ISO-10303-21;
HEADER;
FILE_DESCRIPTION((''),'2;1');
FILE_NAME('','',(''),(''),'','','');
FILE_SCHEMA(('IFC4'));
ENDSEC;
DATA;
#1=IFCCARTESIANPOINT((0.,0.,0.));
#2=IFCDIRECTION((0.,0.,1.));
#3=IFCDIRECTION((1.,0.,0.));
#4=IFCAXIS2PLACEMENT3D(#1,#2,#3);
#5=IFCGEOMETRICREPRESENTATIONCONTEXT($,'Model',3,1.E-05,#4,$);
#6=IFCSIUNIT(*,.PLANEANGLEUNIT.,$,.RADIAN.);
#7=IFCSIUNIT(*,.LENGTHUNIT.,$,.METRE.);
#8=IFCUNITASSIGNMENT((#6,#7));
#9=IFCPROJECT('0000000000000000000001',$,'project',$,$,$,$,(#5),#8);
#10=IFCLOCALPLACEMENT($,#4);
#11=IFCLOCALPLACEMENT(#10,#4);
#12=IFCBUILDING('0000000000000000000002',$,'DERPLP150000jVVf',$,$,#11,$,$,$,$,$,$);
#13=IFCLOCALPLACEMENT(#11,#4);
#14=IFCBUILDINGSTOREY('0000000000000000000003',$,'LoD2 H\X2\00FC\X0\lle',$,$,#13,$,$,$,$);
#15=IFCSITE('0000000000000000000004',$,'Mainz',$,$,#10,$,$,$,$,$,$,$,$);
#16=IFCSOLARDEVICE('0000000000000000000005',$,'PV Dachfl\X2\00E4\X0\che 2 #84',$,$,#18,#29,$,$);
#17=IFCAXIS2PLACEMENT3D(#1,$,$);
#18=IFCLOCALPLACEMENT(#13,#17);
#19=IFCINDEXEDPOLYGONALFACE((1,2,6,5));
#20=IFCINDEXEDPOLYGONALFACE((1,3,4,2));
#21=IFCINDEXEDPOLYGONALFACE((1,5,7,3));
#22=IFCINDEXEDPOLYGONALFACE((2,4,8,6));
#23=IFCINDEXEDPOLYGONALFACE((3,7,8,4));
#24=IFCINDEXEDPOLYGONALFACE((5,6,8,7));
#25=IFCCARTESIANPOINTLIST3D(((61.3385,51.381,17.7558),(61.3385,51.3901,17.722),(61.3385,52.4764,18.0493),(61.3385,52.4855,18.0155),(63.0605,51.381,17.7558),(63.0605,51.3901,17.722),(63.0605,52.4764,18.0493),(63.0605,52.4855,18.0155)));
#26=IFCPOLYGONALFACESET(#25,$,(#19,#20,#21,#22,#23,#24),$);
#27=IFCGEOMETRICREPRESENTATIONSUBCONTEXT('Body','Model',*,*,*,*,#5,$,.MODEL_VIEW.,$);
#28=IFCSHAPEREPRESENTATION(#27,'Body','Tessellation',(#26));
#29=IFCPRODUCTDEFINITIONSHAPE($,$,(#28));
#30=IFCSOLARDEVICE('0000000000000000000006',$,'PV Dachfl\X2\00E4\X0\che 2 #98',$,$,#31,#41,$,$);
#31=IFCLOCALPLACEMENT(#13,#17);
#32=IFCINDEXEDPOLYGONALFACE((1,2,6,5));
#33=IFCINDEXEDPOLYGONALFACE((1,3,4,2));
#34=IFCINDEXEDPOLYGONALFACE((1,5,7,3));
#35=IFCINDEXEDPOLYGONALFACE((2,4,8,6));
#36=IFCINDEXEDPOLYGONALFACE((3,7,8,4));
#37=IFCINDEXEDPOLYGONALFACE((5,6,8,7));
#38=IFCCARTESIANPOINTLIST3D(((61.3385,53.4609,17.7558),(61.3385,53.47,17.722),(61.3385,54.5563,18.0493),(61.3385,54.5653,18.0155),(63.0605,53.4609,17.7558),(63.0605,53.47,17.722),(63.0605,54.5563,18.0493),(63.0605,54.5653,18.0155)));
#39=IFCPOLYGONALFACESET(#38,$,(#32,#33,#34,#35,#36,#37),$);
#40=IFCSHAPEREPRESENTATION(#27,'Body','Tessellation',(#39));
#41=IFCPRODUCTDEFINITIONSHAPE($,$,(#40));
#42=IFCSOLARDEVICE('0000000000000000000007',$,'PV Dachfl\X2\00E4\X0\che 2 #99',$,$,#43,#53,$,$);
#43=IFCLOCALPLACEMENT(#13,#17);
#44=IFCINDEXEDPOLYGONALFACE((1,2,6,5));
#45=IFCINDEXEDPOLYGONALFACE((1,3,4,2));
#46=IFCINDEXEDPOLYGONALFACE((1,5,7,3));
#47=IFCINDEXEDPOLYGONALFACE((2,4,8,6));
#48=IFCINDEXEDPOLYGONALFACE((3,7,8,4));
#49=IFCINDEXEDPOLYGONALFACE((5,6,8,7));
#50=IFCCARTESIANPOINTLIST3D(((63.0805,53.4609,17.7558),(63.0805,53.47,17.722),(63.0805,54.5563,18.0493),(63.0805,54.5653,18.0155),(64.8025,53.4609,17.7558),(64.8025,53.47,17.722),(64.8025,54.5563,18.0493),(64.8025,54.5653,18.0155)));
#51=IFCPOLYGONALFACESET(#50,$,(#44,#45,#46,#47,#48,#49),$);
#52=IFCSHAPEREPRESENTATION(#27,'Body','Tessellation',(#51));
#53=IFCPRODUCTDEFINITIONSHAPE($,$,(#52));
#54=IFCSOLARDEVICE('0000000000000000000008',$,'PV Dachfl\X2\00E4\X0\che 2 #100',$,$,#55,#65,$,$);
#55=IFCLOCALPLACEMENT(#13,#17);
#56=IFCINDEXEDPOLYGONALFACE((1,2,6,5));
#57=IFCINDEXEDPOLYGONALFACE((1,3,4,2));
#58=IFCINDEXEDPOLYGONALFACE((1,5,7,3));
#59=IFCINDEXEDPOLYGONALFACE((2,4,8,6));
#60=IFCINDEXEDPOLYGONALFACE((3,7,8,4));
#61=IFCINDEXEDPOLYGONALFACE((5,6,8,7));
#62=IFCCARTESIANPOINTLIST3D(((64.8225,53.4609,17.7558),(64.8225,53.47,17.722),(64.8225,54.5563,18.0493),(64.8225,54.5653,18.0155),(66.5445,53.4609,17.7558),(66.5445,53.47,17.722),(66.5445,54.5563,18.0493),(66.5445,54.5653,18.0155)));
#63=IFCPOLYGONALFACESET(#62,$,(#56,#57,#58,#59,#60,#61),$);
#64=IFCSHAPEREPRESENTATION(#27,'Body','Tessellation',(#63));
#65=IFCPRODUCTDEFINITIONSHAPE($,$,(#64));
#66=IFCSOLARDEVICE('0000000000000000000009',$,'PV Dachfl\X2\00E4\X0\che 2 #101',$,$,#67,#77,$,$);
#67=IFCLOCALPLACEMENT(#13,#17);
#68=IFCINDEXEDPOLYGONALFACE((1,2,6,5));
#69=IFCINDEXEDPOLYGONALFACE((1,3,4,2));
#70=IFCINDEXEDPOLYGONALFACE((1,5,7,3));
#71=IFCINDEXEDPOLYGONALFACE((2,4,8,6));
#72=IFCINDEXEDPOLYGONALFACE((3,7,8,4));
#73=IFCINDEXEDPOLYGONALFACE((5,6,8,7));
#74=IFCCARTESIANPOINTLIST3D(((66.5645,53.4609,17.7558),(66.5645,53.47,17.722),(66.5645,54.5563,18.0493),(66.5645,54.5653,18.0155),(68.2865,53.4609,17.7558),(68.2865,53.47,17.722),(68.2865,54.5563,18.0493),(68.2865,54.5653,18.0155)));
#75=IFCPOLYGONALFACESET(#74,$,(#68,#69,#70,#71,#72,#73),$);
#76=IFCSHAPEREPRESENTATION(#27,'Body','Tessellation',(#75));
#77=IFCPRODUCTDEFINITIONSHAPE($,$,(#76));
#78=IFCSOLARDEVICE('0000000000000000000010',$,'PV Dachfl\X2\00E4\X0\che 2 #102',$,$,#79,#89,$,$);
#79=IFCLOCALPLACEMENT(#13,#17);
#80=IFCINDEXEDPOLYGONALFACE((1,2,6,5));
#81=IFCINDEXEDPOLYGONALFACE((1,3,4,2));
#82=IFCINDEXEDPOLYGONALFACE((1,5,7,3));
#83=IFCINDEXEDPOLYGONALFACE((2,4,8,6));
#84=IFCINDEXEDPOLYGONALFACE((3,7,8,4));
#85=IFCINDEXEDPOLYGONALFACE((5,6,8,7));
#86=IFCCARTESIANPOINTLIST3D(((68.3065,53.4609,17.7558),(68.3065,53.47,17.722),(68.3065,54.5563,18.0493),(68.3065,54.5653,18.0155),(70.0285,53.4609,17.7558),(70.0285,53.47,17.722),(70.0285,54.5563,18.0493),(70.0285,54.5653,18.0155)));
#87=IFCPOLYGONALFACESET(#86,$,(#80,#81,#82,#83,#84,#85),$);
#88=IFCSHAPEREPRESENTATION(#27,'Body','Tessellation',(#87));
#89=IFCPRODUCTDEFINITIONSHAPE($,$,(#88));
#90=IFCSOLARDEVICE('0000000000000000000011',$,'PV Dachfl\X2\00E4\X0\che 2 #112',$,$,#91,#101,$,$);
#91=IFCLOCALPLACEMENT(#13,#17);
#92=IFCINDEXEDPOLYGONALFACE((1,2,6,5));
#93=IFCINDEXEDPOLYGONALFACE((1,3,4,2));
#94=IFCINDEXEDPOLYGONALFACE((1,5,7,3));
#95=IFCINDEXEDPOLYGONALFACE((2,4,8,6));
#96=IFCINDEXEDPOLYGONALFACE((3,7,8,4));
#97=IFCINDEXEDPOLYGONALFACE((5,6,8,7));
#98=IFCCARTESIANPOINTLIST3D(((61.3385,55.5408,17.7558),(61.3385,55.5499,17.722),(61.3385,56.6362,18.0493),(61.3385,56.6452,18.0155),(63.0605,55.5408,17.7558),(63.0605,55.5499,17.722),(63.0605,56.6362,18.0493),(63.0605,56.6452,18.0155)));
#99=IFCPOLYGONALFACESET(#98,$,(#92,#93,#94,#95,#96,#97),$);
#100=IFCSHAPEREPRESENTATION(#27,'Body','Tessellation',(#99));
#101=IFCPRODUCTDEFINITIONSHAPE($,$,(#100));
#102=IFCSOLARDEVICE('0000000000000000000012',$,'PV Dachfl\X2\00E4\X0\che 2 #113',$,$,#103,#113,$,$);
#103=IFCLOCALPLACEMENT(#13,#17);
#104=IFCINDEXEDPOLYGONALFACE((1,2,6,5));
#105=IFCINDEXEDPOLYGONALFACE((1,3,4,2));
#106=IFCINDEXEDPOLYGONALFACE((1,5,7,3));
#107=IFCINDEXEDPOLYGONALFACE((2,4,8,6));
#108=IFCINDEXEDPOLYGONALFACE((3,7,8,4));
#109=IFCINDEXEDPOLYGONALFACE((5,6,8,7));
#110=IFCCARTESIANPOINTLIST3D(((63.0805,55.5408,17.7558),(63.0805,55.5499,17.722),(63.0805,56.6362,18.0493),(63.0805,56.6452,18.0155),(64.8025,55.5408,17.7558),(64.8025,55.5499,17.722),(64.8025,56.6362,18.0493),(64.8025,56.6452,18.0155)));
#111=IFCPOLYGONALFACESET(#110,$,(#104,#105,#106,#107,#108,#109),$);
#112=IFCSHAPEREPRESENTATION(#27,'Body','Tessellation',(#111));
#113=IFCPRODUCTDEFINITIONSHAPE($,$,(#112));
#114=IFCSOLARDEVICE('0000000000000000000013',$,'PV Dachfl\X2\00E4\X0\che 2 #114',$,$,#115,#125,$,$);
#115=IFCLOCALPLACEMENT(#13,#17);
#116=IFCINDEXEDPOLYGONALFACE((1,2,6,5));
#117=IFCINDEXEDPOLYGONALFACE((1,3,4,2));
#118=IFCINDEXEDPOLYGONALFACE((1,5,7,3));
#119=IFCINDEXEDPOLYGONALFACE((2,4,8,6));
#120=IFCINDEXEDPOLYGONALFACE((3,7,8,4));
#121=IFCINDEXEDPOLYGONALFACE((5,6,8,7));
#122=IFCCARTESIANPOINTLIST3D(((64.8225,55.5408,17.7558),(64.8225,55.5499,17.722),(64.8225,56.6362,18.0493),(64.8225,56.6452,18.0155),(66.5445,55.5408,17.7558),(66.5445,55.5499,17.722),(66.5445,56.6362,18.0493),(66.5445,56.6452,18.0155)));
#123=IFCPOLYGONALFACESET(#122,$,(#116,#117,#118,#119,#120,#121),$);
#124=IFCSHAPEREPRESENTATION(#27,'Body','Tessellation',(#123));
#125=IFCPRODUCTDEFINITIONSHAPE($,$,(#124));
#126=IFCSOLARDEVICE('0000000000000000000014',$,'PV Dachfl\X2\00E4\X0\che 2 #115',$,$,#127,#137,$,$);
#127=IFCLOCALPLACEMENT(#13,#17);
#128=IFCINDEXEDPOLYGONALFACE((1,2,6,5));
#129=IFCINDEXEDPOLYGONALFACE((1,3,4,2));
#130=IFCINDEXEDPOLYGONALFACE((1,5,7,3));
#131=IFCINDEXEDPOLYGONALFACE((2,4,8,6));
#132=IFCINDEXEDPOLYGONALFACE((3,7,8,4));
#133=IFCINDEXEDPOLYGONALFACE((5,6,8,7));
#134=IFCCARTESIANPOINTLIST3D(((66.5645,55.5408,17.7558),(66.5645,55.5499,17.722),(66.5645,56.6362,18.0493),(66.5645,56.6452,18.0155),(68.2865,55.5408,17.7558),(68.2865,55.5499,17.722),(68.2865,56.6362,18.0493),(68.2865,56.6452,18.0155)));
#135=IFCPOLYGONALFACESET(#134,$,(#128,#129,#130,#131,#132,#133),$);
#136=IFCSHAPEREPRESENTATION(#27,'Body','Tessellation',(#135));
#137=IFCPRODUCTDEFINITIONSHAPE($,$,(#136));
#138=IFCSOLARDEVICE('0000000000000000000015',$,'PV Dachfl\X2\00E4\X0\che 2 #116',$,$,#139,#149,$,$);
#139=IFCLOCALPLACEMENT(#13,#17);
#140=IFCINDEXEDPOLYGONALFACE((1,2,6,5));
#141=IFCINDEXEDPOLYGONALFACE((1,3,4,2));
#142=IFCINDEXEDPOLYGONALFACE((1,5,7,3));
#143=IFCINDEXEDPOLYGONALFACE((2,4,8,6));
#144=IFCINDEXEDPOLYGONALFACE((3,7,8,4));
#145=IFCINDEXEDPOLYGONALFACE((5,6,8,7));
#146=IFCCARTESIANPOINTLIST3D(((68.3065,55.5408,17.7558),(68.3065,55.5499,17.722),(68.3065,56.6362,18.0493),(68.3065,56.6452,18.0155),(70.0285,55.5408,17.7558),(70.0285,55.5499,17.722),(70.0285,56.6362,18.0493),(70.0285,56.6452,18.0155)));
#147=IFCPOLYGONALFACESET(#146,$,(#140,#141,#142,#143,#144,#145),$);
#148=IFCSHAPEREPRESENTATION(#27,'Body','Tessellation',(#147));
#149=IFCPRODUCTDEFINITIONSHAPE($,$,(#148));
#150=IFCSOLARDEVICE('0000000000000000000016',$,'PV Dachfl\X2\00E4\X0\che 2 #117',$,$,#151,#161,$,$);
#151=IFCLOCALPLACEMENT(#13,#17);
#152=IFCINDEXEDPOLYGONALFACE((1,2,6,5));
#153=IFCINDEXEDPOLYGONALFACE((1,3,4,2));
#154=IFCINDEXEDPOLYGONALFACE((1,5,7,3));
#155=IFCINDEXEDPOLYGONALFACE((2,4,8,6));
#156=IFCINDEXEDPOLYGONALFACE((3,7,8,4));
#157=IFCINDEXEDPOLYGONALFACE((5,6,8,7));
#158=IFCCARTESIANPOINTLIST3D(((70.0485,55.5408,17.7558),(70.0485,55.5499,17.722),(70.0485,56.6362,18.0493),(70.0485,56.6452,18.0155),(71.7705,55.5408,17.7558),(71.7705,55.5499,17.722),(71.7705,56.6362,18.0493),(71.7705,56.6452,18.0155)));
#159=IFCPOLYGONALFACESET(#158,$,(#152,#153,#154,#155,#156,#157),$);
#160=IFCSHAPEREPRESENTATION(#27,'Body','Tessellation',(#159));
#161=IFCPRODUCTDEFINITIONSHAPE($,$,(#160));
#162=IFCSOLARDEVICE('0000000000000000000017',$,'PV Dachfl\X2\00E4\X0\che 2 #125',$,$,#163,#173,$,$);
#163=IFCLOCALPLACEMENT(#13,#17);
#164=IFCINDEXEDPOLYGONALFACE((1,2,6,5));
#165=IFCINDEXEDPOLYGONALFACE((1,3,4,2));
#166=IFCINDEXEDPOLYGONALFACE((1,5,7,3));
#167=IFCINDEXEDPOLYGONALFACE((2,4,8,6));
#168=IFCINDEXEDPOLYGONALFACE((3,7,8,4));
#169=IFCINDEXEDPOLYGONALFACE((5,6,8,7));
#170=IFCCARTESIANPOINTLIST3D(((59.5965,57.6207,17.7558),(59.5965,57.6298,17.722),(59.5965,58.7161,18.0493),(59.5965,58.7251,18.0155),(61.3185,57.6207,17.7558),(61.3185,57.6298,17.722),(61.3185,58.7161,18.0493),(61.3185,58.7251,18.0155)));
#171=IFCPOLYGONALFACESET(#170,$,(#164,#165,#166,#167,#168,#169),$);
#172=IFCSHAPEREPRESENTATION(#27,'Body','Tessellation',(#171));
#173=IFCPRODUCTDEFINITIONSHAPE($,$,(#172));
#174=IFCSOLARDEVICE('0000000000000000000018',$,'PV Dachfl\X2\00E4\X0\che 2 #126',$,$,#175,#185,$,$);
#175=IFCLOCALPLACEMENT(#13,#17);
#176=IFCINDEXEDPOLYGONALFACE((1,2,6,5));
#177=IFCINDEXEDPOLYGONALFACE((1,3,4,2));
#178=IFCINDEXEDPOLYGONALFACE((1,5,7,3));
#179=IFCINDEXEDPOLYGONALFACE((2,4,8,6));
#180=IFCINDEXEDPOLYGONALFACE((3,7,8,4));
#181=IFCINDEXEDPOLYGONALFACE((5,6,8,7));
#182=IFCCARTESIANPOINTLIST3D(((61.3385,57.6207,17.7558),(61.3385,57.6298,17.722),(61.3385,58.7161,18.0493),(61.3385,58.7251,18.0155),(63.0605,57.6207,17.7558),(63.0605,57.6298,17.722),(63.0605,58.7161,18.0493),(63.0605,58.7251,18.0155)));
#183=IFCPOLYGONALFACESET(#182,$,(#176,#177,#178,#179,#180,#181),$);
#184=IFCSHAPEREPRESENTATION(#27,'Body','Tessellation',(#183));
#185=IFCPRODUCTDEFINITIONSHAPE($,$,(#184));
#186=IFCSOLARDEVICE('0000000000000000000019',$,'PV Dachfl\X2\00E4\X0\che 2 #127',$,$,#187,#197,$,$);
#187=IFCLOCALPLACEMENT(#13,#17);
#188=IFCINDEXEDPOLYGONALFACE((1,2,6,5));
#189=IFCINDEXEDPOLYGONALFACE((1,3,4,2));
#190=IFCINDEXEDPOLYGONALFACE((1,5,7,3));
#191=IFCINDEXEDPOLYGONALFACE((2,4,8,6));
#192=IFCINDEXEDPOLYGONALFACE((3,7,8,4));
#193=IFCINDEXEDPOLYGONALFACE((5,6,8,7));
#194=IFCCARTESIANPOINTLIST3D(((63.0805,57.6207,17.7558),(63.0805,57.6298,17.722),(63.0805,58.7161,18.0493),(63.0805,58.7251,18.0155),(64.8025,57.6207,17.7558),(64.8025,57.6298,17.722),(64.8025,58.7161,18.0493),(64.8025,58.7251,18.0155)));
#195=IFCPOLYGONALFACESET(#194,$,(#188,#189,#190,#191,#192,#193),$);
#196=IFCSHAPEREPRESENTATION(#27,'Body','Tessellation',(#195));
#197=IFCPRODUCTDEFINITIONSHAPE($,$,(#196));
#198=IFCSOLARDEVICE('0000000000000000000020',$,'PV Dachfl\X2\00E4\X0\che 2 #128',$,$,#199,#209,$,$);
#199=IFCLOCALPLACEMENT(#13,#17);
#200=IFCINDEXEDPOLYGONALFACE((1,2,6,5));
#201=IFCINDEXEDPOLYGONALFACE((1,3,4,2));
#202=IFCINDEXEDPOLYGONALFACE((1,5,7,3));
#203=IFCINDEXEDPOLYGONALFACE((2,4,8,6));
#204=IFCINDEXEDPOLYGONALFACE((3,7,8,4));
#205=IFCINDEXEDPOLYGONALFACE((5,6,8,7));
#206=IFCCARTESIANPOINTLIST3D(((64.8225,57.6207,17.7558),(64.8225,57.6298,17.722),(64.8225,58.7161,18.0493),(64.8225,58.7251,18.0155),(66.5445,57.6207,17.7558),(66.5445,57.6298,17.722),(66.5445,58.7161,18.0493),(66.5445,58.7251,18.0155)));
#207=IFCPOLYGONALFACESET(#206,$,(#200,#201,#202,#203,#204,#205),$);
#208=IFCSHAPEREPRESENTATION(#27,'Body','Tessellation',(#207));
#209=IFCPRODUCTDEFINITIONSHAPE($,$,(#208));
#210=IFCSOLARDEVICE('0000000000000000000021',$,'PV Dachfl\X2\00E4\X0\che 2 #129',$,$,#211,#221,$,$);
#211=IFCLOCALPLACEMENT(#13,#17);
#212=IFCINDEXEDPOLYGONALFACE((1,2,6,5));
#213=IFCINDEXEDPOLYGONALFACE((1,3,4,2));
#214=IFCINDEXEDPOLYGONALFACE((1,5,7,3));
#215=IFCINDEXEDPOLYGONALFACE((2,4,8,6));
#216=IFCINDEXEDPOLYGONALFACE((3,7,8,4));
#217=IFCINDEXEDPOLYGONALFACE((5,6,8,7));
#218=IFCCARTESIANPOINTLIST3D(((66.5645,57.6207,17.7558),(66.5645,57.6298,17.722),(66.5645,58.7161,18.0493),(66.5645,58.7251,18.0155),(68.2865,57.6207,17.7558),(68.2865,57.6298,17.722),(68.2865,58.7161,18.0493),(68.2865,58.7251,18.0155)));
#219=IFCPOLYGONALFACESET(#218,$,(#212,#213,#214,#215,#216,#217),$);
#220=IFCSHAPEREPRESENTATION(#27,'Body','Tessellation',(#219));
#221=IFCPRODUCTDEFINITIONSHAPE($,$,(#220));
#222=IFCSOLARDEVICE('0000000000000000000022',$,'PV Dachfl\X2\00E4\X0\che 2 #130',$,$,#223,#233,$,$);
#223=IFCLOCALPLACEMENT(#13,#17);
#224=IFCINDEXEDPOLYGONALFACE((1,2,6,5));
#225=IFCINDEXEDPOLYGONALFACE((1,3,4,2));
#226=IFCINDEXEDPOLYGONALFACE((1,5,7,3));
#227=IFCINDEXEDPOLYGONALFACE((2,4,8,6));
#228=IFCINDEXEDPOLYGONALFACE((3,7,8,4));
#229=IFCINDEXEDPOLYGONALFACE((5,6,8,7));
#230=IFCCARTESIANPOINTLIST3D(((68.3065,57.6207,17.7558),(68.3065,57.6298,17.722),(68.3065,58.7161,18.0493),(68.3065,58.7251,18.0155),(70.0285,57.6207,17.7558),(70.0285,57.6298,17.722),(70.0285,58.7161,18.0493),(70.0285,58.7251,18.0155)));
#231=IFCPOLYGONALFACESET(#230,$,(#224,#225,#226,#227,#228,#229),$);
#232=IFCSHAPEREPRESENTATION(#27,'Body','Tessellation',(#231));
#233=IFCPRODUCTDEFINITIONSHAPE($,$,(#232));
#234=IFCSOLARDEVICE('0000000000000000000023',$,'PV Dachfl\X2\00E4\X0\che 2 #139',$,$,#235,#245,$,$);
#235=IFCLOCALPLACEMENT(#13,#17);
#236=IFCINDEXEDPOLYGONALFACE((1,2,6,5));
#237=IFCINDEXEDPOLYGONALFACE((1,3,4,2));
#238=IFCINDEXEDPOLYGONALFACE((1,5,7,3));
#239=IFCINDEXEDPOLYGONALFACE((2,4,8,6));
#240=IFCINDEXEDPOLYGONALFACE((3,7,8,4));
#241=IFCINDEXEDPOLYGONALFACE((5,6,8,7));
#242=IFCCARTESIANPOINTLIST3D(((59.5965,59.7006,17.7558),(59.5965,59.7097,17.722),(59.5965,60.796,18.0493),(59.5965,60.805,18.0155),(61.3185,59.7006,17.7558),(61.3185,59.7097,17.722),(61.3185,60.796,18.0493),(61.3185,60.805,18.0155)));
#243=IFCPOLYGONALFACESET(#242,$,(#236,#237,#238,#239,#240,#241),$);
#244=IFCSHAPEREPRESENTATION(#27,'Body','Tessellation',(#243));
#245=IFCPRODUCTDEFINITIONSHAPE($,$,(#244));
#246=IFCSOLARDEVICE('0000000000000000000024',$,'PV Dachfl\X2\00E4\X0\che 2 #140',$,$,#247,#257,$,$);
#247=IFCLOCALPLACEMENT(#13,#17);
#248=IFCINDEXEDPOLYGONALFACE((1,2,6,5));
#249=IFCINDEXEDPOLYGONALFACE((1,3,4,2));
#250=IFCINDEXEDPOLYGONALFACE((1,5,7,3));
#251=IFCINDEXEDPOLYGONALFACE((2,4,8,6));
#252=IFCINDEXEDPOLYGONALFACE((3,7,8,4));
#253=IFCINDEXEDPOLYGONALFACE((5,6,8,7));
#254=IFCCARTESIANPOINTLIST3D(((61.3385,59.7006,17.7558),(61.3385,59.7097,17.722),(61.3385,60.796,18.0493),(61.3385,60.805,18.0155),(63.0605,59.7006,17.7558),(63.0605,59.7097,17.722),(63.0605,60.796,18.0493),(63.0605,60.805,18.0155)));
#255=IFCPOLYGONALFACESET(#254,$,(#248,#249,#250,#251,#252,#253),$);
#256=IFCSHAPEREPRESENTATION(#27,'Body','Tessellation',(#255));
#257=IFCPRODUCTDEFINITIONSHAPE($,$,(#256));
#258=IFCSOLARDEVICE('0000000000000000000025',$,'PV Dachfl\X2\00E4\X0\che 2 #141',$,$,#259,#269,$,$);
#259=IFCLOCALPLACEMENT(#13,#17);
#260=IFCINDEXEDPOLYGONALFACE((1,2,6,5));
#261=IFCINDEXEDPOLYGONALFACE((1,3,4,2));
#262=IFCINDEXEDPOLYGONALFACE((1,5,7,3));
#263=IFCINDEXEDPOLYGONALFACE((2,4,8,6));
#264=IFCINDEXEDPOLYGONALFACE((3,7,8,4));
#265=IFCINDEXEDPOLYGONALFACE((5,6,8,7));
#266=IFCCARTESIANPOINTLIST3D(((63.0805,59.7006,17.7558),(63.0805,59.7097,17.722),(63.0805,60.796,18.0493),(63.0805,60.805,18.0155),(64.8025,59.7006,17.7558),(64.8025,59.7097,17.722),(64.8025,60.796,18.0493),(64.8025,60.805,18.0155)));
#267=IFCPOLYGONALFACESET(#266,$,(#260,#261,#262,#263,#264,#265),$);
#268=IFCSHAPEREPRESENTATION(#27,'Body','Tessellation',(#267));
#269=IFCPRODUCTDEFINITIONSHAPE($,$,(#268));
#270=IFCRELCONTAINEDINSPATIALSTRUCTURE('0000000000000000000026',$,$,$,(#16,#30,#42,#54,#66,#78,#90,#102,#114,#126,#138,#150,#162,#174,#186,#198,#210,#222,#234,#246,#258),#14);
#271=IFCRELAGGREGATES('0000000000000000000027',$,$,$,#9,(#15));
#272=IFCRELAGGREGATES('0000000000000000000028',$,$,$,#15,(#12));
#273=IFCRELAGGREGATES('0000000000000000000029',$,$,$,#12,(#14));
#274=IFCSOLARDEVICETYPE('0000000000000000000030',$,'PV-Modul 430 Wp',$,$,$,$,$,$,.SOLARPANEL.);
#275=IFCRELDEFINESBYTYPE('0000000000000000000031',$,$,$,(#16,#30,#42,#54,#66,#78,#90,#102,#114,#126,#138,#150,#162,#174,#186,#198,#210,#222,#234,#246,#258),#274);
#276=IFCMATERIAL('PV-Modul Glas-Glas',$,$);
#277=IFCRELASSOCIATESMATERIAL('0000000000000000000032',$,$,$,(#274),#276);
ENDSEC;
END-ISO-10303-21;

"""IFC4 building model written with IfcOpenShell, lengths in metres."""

from ifc_helpers import new_model, si_unit, frame, frame_2d, origin, origin_with_axes, place, context, subcontext, project, spatial, rectangle, extrude, source, transform, mapped, material, type_object, type_shapes, element, save


model = new_model("IFC4")

# Units and contexts
model_context = context("Model", 3, precision=1e-05, world=origin_with_axes())
body_context = subcontext(model_context, "Body", "Model", "MODEL_VIEW")
ifc_project = project(units=[si_unit("PLANEANGLEUNIT", "RADIAN"), si_unit("LENGTHUNIT", "METRE")], contexts=[model_context])

# Site, building, storey
site_placement = place(None, origin_with_axes())
site = spatial("IfcSite", under=ifc_project, at=site_placement, Name="Mainz")
building_placement = place(site_placement, origin_with_axes())
building = spatial("IfcBuilding", under=site, at=building_placement, Name="DERPLP150000jVVf")
storey_placement = place(building_placement, origin_with_axes())
storey = spatial("IfcBuildingStorey", under=building, at=storey_placement, Name="LoD2 Hülle")

# Solar devices
ifc_material = material(Name="PV-Modul Glas-Glas")
solar_device_type = type_object("IfcSolarDeviceType", Name="PV-Modul 430 Wp", PredefinedType="SOLARPANEL", material=ifc_material)
shared_shape = source(origin_with_axes(), body_context, "Body", "SweptSolid", [
    extrude(rectangle(XDim=1.722, YDim=1.134, at=frame_2d((0.861, 0.567))), origin(), (0.0, 0.0, 1.0), 0.035),
])
type_shapes(solar_device_type, [shared_shape])
for number, where, z_axis, x_axis, name in (
    (1, (61.3385, 51.3901, 17.722), (0.0, -0.258819, 0.965926), (1.0, 0.0, 0.0), "PV Dachfläche 2 #84"),
    (2, (61.3385, 53.47, 17.722), (0.0, -0.258819, 0.965926), (1.0, 0.0, 0.0), "PV Dachfläche 2 #98"),
    (3, (63.0805, 53.47, 17.722), (0.0, -0.258819, 0.965926), (1.0, 0.0, 0.0), "PV Dachfläche 2 #99"),
    (4, (64.8225, 53.47, 17.722), (0.0, -0.258819, 0.965926), (1.0, 0.0, 0.0), "PV Dachfläche 2 #100"),
    (5, (66.5645, 53.47, 17.722), (0.0, -0.258819, 0.965926), (1.0, 0.0, 0.0), "PV Dachfläche 2 #101"),
    (6, (68.3065, 53.47, 17.722), (0.0, -0.258819, 0.965926), (1.0, 0.0, 0.0), "PV Dachfläche 2 #102"),
    (7, (61.3385, 55.5499, 17.722), (0.0, -0.258819, 0.965926), (1.0, 0.0, 0.0), "PV Dachfläche 2 #112"),
    (8, (63.0805, 55.5499, 17.722), (0.0, -0.258819, 0.965926), (1.0, 0.0, 0.0), "PV Dachfläche 2 #113"),
    (9, (64.8225, 55.5499, 17.722), (0.0, -0.258819, 0.965926), (1.0, 0.0, 0.0), "PV Dachfläche 2 #114"),
    (10, (66.5645, 55.5499, 17.722), (0.0, -0.258819, 0.965926), (1.0, 0.0, 0.0), "PV Dachfläche 2 #115"),
    (11, (68.3065, 55.5499, 17.722), (0.0, -0.258819, 0.965926), (1.0, 0.0, 0.0), "PV Dachfläche 2 #116"),
    (12, (70.0485, 55.5499, 17.722), (0.0, -0.258819, 0.965926), (1.0, 0.0, 0.0), "PV Dachfläche 2 #117"),
    (13, (59.5965, 57.6298, 17.722), (0.0, -0.258819, 0.965926), (1.0, 0.0, 0.0), "PV Dachfläche 2 #125"),
    (14, (61.3385, 57.6298, 17.722), (0.0, -0.258819, 0.965926), (1.0, 0.0, 0.0), "PV Dachfläche 2 #126"),
    (15, (63.0805, 57.6298, 17.722), (0.0, -0.258819, 0.965926), (1.0, 0.0, 0.0), "PV Dachfläche 2 #127"),
    (16, (64.8225, 57.6298, 17.722), (0.0, -0.258819, 0.965926), (1.0, 0.0, 0.0), "PV Dachfläche 2 #128"),
    (17, (66.5645, 57.6298, 17.722), (0.0, -0.258819, 0.965926), (1.0, 0.0, 0.0), "PV Dachfläche 2 #129"),
    (18, (68.3065, 57.6298, 17.722), (0.0, -0.258819, 0.965926), (1.0, 0.0, 0.0), "PV Dachfläche 2 #130"),
    (19, (59.5965, 59.7097, 17.722), (0.0, -0.258819, 0.965926), (1.0, 0.0, 0.0), "PV Dachfläche 2 #139"),
    (20, (61.3385, 59.7097, 17.722), (0.0, -0.258819, 0.965926), (1.0, 0.0, 0.0), "PV Dachfläche 2 #140"),
    (21, (63.0805, 59.7097, 17.722), (0.0, -0.258819, 0.965926), (1.0, 0.0, 0.0), "PV Dachfläche 2 #141"),
):
    element("IfcSolarDevice", number, at=place(storey_placement, frame(where, z_axis=z_axis, x_axis=x_axis)), inside=storey, type_object=solar_device_type, Name=name, context=body_context, shape_type="MappedRepresentation", body=[
        mapped(shared_shape, transform((0.0, 0.0, 0.0), x_axis=(1.0, 0.0, 0.0), y_axis=(0.0, 1.0, 0.0), z_axis=(0.0, 0.0, 1.0), scale=1.0)),
    ])

save(model, "model.ifc")
